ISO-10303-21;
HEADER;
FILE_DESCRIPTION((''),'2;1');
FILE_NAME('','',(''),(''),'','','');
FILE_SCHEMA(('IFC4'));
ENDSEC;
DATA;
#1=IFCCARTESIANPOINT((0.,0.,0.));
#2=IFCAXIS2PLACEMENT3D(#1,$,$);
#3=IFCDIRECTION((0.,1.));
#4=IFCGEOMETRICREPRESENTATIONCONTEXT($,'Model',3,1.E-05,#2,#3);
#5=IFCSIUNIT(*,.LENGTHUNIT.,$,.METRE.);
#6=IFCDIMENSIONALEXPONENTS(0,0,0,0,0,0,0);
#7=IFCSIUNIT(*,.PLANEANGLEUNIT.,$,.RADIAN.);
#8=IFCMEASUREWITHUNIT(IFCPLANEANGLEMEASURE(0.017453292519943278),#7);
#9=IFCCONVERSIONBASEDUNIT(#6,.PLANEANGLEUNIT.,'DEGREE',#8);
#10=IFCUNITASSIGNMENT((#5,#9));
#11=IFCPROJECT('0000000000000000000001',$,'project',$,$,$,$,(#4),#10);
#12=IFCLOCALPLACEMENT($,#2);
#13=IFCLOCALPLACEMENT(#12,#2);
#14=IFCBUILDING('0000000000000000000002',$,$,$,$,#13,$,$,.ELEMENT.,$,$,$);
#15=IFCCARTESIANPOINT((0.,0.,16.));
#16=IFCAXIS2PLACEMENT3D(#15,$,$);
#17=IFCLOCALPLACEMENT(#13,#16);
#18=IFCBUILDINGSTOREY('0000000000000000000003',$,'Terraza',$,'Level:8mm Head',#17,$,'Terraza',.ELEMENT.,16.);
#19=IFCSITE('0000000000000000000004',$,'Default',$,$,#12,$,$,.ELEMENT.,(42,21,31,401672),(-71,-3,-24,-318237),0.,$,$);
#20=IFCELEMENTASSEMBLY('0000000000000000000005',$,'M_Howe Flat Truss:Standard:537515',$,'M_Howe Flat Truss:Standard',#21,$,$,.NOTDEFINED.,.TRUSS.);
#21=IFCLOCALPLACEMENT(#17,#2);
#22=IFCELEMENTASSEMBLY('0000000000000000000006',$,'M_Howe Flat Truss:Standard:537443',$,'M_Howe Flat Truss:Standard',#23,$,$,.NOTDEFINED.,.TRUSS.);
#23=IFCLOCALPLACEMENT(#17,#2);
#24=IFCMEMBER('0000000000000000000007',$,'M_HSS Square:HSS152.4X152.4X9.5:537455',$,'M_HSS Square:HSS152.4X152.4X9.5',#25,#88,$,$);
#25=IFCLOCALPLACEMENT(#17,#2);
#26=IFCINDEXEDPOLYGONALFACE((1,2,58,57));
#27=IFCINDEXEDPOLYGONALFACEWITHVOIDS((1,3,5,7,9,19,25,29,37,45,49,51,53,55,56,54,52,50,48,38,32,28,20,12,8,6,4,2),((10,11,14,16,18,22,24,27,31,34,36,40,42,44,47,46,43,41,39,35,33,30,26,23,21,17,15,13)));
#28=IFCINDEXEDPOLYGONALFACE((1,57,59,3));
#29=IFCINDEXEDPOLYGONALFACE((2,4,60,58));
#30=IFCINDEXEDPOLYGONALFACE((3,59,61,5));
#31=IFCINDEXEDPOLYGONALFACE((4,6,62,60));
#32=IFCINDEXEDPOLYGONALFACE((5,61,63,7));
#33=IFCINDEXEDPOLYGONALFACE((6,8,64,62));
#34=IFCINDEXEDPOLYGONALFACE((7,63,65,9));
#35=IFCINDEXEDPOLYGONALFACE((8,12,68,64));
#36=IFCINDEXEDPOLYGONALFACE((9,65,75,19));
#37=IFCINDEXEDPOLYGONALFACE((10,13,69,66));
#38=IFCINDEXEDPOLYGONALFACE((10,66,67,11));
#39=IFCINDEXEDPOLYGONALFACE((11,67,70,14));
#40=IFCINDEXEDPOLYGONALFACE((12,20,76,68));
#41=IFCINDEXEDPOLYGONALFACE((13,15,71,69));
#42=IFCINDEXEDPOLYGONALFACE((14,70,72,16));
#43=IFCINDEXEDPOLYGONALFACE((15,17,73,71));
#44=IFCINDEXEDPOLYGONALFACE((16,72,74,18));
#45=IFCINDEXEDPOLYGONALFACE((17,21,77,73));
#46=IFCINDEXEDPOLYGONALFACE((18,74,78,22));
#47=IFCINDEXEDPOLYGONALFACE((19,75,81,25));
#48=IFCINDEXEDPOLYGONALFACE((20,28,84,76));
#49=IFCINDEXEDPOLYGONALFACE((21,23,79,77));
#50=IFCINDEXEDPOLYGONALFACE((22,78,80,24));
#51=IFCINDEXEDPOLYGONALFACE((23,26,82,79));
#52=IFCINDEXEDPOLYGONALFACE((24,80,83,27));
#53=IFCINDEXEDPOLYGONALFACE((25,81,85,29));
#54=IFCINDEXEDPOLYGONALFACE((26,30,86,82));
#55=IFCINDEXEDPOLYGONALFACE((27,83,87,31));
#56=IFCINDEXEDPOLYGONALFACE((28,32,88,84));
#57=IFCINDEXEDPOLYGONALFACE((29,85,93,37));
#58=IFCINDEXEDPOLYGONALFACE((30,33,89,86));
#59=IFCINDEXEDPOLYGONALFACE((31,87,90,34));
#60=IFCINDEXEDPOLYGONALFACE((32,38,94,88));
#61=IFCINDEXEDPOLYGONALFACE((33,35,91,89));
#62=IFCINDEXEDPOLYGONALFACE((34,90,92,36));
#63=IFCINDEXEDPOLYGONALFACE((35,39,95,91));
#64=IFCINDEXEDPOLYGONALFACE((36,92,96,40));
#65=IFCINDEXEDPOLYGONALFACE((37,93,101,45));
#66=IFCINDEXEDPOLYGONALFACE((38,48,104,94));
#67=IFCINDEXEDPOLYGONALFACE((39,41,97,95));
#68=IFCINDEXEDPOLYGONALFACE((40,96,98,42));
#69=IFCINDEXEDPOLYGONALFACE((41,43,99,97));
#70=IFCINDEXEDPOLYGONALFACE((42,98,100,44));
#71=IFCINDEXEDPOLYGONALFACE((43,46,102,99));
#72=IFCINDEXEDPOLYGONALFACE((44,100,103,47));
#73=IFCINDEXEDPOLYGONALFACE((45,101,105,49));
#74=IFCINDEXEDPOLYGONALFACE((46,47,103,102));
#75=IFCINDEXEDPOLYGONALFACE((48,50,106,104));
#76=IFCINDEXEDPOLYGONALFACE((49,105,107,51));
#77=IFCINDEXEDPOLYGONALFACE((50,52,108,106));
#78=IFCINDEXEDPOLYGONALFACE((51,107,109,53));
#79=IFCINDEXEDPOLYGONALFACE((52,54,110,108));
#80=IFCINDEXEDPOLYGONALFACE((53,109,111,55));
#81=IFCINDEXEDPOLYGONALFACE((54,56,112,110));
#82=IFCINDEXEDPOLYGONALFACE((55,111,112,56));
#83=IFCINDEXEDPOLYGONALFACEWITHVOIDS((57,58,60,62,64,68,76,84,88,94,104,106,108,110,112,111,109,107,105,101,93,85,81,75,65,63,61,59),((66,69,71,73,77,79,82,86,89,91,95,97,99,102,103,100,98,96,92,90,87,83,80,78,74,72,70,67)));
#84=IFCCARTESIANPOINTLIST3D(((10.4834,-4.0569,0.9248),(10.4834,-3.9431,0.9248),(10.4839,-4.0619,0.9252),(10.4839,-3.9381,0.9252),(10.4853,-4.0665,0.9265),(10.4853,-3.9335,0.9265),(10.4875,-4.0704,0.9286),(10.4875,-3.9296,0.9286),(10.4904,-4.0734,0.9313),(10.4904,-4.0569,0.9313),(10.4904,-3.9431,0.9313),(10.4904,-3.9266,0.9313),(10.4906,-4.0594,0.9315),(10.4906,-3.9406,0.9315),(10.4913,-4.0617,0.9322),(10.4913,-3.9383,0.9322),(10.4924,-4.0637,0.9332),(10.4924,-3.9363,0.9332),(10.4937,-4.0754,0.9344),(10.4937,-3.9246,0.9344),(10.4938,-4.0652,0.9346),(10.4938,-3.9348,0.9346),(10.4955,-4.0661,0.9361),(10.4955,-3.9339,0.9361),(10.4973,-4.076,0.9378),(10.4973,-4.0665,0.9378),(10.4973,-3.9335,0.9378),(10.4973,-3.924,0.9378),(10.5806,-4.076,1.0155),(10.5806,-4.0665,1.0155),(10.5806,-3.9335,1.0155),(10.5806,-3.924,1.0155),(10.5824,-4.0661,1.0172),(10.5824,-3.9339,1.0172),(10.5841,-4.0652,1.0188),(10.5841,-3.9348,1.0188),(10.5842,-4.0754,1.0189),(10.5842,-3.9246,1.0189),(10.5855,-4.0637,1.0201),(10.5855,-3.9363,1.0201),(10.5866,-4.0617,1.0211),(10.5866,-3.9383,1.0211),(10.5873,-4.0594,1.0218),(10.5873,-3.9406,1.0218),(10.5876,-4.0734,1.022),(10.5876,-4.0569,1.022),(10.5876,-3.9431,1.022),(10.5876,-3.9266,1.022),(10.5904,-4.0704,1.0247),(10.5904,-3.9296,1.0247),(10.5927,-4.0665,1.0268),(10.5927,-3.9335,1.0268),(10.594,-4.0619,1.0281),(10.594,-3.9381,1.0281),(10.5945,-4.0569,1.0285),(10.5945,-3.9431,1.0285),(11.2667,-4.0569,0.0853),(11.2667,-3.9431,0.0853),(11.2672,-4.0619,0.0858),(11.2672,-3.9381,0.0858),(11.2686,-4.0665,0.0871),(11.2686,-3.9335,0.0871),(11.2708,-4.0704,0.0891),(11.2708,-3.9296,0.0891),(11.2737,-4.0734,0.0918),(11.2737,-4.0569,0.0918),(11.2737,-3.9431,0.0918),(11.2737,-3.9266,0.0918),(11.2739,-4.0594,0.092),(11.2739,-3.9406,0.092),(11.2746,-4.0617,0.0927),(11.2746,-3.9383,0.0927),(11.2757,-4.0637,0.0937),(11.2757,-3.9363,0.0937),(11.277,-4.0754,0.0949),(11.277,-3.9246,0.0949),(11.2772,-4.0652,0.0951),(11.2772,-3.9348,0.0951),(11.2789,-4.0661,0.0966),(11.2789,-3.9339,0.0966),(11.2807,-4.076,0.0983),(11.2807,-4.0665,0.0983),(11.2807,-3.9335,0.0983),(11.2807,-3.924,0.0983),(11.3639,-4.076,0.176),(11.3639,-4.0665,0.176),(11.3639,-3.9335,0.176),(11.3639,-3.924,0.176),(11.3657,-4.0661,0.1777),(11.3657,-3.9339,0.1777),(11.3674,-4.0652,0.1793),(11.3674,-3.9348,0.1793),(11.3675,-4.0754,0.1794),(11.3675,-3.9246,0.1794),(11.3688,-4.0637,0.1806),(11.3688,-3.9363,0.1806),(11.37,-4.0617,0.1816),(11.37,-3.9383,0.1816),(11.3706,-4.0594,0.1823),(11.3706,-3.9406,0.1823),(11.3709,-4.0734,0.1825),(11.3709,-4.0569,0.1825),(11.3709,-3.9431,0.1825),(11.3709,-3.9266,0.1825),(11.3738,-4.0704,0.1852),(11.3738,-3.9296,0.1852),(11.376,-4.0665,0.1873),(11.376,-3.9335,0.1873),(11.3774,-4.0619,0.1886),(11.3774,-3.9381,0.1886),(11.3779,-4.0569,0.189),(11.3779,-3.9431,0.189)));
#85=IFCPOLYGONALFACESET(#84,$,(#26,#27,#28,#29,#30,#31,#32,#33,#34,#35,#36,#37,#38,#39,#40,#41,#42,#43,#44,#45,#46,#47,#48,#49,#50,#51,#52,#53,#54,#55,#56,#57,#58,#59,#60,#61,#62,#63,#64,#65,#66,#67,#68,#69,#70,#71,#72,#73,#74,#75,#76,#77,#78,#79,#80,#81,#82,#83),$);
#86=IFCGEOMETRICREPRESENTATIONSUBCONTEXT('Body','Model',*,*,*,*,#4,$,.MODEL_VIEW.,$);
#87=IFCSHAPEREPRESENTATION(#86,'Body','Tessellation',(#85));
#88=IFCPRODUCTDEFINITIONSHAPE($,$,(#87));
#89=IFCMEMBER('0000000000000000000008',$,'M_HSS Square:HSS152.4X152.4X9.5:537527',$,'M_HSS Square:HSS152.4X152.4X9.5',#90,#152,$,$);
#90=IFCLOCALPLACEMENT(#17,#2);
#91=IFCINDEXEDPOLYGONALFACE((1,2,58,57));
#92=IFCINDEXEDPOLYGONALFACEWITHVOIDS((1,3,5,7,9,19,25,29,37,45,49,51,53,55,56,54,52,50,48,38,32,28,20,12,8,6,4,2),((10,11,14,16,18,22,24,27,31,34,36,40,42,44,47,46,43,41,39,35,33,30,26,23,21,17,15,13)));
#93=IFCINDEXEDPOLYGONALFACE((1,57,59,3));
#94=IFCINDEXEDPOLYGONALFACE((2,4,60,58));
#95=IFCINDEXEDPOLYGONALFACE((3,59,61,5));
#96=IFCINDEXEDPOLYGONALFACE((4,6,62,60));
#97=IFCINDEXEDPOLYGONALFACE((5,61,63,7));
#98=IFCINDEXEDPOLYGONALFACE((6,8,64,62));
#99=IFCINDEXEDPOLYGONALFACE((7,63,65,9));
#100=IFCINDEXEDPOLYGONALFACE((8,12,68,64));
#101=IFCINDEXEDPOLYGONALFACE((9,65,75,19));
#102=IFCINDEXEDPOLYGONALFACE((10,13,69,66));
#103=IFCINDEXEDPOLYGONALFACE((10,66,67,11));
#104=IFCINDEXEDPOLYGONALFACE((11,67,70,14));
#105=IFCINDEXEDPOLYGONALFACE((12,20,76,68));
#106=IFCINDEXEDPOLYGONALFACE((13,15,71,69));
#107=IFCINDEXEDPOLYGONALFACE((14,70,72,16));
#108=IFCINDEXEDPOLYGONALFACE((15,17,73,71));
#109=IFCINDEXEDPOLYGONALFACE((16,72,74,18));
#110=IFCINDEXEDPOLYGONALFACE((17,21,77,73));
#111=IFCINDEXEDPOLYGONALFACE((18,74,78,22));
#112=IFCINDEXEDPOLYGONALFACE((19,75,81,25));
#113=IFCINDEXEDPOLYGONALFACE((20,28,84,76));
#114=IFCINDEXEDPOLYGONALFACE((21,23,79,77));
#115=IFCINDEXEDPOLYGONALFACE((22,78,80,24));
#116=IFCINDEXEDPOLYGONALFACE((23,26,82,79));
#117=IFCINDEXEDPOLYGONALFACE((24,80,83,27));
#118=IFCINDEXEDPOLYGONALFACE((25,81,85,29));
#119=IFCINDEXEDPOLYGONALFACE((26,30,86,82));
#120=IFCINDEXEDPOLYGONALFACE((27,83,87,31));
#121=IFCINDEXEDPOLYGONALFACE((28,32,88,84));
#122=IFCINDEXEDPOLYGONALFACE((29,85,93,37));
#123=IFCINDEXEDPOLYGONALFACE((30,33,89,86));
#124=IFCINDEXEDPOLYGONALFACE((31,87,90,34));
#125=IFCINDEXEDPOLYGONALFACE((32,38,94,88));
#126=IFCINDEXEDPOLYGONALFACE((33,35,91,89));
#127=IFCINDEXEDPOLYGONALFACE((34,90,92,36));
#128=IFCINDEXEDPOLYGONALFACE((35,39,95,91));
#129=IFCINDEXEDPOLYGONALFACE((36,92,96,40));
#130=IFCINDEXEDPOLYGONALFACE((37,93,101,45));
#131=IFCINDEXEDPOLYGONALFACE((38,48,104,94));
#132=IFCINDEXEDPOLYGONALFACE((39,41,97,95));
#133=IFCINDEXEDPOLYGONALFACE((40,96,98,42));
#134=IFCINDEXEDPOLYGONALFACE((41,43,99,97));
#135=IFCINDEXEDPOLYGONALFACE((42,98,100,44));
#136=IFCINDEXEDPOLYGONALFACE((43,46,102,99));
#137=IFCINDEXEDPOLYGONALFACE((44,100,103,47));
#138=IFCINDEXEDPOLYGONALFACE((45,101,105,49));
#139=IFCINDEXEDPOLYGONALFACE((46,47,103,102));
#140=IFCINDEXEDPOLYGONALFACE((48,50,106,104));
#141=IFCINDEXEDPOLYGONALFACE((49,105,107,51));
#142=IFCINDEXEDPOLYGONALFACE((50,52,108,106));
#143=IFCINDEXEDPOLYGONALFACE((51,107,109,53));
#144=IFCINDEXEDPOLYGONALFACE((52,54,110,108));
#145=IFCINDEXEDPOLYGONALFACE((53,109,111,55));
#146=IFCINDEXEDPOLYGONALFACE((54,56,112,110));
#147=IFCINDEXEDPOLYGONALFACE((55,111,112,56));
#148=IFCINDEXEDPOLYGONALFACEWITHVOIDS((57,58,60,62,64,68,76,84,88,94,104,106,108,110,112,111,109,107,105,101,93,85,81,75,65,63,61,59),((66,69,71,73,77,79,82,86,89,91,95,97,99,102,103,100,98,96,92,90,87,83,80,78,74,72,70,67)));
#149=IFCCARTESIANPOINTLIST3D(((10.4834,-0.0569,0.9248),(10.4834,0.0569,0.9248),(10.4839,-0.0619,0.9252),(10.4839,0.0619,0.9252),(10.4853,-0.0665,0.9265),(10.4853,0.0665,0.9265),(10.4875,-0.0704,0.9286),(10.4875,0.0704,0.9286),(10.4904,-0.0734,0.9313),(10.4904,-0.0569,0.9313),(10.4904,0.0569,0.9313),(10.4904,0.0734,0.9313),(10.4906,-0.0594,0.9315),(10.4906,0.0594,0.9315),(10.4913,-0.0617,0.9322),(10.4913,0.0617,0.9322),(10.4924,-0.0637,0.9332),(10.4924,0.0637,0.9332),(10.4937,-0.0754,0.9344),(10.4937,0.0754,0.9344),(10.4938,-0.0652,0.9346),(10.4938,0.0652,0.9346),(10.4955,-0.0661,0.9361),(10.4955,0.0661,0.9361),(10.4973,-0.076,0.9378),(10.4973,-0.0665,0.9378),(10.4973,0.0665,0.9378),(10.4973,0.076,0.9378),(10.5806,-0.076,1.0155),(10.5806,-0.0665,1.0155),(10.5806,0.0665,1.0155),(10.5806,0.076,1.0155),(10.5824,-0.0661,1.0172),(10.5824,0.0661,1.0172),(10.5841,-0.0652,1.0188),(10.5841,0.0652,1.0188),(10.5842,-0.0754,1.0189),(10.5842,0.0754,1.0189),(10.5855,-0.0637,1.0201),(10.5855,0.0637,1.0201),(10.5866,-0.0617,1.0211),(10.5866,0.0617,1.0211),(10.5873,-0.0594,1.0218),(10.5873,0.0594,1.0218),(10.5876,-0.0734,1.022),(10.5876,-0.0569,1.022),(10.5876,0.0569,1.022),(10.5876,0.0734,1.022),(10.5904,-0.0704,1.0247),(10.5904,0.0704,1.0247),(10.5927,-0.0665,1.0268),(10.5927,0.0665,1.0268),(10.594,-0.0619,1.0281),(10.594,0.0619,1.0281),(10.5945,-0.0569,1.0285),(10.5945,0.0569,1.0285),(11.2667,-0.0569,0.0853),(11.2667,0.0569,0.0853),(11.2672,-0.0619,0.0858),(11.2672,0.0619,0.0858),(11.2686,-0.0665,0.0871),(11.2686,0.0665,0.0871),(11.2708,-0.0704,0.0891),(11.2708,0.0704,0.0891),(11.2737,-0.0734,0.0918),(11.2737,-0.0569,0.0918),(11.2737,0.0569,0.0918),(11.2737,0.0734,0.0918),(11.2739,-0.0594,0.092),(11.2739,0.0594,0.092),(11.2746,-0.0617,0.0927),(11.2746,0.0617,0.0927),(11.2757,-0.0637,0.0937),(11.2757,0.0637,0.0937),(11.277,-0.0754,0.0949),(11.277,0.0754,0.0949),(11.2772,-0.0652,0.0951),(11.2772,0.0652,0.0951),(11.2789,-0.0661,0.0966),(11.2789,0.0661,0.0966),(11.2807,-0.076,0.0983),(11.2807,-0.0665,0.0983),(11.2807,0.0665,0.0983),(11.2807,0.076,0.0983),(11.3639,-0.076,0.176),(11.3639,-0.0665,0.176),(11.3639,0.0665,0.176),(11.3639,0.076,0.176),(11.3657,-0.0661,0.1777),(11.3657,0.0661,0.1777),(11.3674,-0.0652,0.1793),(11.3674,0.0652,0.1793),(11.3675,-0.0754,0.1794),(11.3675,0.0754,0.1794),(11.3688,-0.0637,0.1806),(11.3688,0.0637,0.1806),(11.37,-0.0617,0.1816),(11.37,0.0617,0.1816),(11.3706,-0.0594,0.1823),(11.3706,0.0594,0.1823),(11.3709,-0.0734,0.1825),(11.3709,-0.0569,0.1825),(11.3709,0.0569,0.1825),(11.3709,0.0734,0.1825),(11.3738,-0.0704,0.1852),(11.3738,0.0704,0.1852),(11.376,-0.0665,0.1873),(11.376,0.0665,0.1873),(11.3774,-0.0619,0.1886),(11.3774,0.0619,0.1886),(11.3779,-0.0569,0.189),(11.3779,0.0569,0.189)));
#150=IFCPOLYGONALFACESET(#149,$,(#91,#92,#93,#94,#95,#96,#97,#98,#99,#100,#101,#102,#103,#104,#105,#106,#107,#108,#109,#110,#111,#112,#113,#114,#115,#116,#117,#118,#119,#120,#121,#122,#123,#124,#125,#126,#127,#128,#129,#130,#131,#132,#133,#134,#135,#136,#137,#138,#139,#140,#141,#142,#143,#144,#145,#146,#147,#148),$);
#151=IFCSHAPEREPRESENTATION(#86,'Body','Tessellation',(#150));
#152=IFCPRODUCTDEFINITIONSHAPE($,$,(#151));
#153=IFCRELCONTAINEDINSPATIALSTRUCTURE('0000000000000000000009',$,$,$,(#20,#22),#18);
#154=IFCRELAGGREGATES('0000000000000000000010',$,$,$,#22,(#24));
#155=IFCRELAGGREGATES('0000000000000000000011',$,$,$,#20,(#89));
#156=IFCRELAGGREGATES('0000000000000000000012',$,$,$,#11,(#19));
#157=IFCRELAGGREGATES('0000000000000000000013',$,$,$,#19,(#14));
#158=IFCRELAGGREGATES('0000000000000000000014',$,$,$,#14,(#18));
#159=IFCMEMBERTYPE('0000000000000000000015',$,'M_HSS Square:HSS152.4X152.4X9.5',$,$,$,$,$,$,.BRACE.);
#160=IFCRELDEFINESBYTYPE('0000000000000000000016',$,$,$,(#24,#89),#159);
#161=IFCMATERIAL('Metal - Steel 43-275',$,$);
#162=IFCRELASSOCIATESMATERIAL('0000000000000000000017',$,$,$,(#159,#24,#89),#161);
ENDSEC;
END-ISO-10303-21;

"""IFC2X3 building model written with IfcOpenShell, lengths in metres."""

from ifc_helpers import new_model, entity, si_unit, converted_unit, direction, frame, frame_2d, origin, place, context, subcontext, project, spatial, polyline, circle_curve, parameter, trimmed, segment, composite_curve, outline, extrude, source, transform, mapped, material, type_object, type_shapes, element, aggregate, save


model = new_model("IFC2X3")

# Units and contexts
model_context = context("Model", 3, precision=1e-05, world=origin(), true_north=direction((0.0, 1.0)))
body_context = subcontext(model_context, "Body", "Model", "MODEL_VIEW")
ifc_project = project(units=[si_unit("LENGTHUNIT", "METRE"), converted_unit("PLANEANGLEUNIT", "DEGREE", entity("IfcPlaneAngleMeasure", 0.017453292519943278), si_unit("PLANEANGLEUNIT", "RADIAN"), dimensions=[0, 0, 0, 0, 0, 0, 0])], contexts=[model_context])

# Site, building, storey
site_placement = place(None, origin())
site = spatial("IfcSite", under=ifc_project, at=site_placement, Name="Default", CompositionType="ELEMENT", RefLatitude=(42, 21, 31, 401672), RefLongitude=(-71, -3, -24, -318237), RefElevation=0.0)
building_placement = place(site_placement, origin())
building = spatial("IfcBuilding", under=site, at=building_placement, CompositionType="ELEMENT")
storey_placement = place(building_placement, frame((0.0, 0.0, 16.0)))
storey = spatial("IfcBuildingStorey", under=building, at=storey_placement, Name="Terraza", ObjectType="Level:8mm Head", LongName="Terraza", CompositionType="ELEMENT", Elevation=16.0)

# Element assemblies
assembly_1_placement = place(storey_placement, origin())
assembly_1 = element("IfcElementAssembly", 1, at=assembly_1_placement, inside=storey, Name="M_Howe Flat Truss:Standard:537515", ObjectType="M_Howe Flat Truss:Standard", AssemblyPlace="NOTDEFINED", PredefinedType="TRUSS")
ifc_material_1 = material(Name="Metal - Steel 43-275")
assembly_2_placement = place(storey_placement, origin())
assembly_2 = element("IfcElementAssembly", 2, at=assembly_2_placement, inside=storey, Name="M_Howe Flat Truss:Standard:537443", ObjectType="M_Howe Flat Truss:Standard", AssemblyPlace="NOTDEFINED", PredefinedType="TRUSS")

# Members
member_type_1 = type_object("IfcMemberType", Name="M_HSS Square:HSS152.4X152.4X9.5", PredefinedType="BRACE", material=ifc_material_1)
shared_shape_1 = source(origin(), body_context, "Body", "SweptSolid", [
    extrude(outline(composite_curve([segment(polyline([(-0.0569, -0.076), (0.0569, -0.076)]), True, "CONTINUOUS"), segment(trimmed(circle_curve(frame_2d((0.0569, -0.0569), x_axis=(0.0, 1.0)), 0.0191), [parameter(180.0)], [parameter(270.0)], True, "PARAMETER"), True, "CONTINUOUS"), segment(polyline([(0.076, -0.0569), (0.076, 0.0569)]), True, "CONTINUOUS"), segment(trimmed(circle_curve(frame_2d((0.0569, 0.0569), x_axis=(0.0, 1.0)), 0.0191), [parameter(270.0)], [parameter(0.0)], True, "PARAMETER"), True, "CONTINUOUS"), segment(polyline([(0.0569, 0.076), (-0.0569, 0.076)]), True, "CONTINUOUS"), segment(trimmed(circle_curve(frame_2d((-0.0569, 0.0569), x_axis=(0.0, 1.0)), 0.0191), [parameter(0.0)], [parameter(90.0)], True, "PARAMETER"), True, "CONTINUOUS"), segment(polyline([(-0.076, 0.0569), (-0.076, -0.0569)]), True, "CONTINUOUS"), segment(trimmed(circle_curve(frame_2d((-0.0569, -0.0569), x_axis=(0.0, 1.0)), 0.0191), [parameter(90.0)], [parameter(180.0)], True, "PARAMETER"), True, "CONTINUOUS")], self_intersect=False), holes=[composite_curve([segment(trimmed(circle_curve(frame_2d((-0.0569, 0.0569), x_axis=(0.0, 1.0)), 0.0095), [parameter(360.0)], [parameter(90.0)], True, "PARAMETER"), False, "CONTINUOUS"), segment(polyline([(-0.0569, 0.0665), (0.0569, 0.0665)]), True, "CONTINUOUS"), segment(trimmed(circle_curve(frame_2d((0.0569, 0.0569), x_axis=(0.0, 1.0)), 0.0095), [parameter(270.0)], [parameter(360.0)], True, "PARAMETER"), False, "CONTINUOUS"), segment(polyline([(0.0665, 0.0569), (0.0665, -0.0569)]), True, "CONTINUOUS"), segment(trimmed(circle_curve(frame_2d((0.0569, -0.0569), x_axis=(0.0, 1.0)), 0.0095), [parameter(180.0)], [parameter(270.0)], True, "PARAMETER"), False, "CONTINUOUS"), segment(polyline([(0.0569, -0.0665), (-0.0569, -0.0665)]), True, "CONTINUOUS"), segment(trimmed(circle_curve(frame_2d((-0.0569, -0.0569), x_axis=(0.0, 1.0)), 0.0095), [parameter(90.0)], [parameter(180.0)], True, "PARAMETER"), False, "CONTINUOUS"), segment(polyline([(-0.0665, -0.0569), (-0.0665, 0.0569)]), True, "CONTINUOUS")], self_intersect=False)]), frame((-0.5665, 0.0, 0.0), z_axis=(1.0, 0.0, 0.0), x_axis=(0.0, 0.0, -1.0)), (0.0, 0.0, 1.0), 1.1482),
])
type_shapes(member_type_1, [shared_shape_1])
member_1_placement = place(assembly_2_placement, frame((10.9254, -4.0, 0.5625), z_axis=(-0.731142, 0.0, -0.682225), x_axis=(0.682225, 0.0, -0.731142)))
member_1 = element("IfcMember", 3, at=member_1_placement, type_object=member_type_1, material=ifc_material_1, Name="M_HSS Square:HSS152.4X152.4X9.5:537455", ObjectType="M_HSS Square:HSS152.4X152.4X9.5", context=body_context, shape_type="MappedRepresentation", body=[
    mapped(shared_shape_1, transform((0.0, 0.0, 0.0), scale=1.0)),
])
aggregate(assembly_2, [member_1])
member_2_placement = place(assembly_1_placement, frame((10.9254, 0.0, 0.5625), z_axis=(-0.731142, 0.0, -0.682225), x_axis=(0.682225, 0.0, -0.731142)))
member_2 = element("IfcMember", 4, at=member_2_placement, type_object=member_type_1, material=ifc_material_1, Name="M_HSS Square:HSS152.4X152.4X9.5:537527", ObjectType="M_HSS Square:HSS152.4X152.4X9.5", context=body_context, shape_type="MappedRepresentation", body=[
    mapped(shared_shape_1, transform((0.0, 0.0, 0.0), scale=1.0)),
])
aggregate(assembly_1, [member_2])

save(model, "model.ifc")
